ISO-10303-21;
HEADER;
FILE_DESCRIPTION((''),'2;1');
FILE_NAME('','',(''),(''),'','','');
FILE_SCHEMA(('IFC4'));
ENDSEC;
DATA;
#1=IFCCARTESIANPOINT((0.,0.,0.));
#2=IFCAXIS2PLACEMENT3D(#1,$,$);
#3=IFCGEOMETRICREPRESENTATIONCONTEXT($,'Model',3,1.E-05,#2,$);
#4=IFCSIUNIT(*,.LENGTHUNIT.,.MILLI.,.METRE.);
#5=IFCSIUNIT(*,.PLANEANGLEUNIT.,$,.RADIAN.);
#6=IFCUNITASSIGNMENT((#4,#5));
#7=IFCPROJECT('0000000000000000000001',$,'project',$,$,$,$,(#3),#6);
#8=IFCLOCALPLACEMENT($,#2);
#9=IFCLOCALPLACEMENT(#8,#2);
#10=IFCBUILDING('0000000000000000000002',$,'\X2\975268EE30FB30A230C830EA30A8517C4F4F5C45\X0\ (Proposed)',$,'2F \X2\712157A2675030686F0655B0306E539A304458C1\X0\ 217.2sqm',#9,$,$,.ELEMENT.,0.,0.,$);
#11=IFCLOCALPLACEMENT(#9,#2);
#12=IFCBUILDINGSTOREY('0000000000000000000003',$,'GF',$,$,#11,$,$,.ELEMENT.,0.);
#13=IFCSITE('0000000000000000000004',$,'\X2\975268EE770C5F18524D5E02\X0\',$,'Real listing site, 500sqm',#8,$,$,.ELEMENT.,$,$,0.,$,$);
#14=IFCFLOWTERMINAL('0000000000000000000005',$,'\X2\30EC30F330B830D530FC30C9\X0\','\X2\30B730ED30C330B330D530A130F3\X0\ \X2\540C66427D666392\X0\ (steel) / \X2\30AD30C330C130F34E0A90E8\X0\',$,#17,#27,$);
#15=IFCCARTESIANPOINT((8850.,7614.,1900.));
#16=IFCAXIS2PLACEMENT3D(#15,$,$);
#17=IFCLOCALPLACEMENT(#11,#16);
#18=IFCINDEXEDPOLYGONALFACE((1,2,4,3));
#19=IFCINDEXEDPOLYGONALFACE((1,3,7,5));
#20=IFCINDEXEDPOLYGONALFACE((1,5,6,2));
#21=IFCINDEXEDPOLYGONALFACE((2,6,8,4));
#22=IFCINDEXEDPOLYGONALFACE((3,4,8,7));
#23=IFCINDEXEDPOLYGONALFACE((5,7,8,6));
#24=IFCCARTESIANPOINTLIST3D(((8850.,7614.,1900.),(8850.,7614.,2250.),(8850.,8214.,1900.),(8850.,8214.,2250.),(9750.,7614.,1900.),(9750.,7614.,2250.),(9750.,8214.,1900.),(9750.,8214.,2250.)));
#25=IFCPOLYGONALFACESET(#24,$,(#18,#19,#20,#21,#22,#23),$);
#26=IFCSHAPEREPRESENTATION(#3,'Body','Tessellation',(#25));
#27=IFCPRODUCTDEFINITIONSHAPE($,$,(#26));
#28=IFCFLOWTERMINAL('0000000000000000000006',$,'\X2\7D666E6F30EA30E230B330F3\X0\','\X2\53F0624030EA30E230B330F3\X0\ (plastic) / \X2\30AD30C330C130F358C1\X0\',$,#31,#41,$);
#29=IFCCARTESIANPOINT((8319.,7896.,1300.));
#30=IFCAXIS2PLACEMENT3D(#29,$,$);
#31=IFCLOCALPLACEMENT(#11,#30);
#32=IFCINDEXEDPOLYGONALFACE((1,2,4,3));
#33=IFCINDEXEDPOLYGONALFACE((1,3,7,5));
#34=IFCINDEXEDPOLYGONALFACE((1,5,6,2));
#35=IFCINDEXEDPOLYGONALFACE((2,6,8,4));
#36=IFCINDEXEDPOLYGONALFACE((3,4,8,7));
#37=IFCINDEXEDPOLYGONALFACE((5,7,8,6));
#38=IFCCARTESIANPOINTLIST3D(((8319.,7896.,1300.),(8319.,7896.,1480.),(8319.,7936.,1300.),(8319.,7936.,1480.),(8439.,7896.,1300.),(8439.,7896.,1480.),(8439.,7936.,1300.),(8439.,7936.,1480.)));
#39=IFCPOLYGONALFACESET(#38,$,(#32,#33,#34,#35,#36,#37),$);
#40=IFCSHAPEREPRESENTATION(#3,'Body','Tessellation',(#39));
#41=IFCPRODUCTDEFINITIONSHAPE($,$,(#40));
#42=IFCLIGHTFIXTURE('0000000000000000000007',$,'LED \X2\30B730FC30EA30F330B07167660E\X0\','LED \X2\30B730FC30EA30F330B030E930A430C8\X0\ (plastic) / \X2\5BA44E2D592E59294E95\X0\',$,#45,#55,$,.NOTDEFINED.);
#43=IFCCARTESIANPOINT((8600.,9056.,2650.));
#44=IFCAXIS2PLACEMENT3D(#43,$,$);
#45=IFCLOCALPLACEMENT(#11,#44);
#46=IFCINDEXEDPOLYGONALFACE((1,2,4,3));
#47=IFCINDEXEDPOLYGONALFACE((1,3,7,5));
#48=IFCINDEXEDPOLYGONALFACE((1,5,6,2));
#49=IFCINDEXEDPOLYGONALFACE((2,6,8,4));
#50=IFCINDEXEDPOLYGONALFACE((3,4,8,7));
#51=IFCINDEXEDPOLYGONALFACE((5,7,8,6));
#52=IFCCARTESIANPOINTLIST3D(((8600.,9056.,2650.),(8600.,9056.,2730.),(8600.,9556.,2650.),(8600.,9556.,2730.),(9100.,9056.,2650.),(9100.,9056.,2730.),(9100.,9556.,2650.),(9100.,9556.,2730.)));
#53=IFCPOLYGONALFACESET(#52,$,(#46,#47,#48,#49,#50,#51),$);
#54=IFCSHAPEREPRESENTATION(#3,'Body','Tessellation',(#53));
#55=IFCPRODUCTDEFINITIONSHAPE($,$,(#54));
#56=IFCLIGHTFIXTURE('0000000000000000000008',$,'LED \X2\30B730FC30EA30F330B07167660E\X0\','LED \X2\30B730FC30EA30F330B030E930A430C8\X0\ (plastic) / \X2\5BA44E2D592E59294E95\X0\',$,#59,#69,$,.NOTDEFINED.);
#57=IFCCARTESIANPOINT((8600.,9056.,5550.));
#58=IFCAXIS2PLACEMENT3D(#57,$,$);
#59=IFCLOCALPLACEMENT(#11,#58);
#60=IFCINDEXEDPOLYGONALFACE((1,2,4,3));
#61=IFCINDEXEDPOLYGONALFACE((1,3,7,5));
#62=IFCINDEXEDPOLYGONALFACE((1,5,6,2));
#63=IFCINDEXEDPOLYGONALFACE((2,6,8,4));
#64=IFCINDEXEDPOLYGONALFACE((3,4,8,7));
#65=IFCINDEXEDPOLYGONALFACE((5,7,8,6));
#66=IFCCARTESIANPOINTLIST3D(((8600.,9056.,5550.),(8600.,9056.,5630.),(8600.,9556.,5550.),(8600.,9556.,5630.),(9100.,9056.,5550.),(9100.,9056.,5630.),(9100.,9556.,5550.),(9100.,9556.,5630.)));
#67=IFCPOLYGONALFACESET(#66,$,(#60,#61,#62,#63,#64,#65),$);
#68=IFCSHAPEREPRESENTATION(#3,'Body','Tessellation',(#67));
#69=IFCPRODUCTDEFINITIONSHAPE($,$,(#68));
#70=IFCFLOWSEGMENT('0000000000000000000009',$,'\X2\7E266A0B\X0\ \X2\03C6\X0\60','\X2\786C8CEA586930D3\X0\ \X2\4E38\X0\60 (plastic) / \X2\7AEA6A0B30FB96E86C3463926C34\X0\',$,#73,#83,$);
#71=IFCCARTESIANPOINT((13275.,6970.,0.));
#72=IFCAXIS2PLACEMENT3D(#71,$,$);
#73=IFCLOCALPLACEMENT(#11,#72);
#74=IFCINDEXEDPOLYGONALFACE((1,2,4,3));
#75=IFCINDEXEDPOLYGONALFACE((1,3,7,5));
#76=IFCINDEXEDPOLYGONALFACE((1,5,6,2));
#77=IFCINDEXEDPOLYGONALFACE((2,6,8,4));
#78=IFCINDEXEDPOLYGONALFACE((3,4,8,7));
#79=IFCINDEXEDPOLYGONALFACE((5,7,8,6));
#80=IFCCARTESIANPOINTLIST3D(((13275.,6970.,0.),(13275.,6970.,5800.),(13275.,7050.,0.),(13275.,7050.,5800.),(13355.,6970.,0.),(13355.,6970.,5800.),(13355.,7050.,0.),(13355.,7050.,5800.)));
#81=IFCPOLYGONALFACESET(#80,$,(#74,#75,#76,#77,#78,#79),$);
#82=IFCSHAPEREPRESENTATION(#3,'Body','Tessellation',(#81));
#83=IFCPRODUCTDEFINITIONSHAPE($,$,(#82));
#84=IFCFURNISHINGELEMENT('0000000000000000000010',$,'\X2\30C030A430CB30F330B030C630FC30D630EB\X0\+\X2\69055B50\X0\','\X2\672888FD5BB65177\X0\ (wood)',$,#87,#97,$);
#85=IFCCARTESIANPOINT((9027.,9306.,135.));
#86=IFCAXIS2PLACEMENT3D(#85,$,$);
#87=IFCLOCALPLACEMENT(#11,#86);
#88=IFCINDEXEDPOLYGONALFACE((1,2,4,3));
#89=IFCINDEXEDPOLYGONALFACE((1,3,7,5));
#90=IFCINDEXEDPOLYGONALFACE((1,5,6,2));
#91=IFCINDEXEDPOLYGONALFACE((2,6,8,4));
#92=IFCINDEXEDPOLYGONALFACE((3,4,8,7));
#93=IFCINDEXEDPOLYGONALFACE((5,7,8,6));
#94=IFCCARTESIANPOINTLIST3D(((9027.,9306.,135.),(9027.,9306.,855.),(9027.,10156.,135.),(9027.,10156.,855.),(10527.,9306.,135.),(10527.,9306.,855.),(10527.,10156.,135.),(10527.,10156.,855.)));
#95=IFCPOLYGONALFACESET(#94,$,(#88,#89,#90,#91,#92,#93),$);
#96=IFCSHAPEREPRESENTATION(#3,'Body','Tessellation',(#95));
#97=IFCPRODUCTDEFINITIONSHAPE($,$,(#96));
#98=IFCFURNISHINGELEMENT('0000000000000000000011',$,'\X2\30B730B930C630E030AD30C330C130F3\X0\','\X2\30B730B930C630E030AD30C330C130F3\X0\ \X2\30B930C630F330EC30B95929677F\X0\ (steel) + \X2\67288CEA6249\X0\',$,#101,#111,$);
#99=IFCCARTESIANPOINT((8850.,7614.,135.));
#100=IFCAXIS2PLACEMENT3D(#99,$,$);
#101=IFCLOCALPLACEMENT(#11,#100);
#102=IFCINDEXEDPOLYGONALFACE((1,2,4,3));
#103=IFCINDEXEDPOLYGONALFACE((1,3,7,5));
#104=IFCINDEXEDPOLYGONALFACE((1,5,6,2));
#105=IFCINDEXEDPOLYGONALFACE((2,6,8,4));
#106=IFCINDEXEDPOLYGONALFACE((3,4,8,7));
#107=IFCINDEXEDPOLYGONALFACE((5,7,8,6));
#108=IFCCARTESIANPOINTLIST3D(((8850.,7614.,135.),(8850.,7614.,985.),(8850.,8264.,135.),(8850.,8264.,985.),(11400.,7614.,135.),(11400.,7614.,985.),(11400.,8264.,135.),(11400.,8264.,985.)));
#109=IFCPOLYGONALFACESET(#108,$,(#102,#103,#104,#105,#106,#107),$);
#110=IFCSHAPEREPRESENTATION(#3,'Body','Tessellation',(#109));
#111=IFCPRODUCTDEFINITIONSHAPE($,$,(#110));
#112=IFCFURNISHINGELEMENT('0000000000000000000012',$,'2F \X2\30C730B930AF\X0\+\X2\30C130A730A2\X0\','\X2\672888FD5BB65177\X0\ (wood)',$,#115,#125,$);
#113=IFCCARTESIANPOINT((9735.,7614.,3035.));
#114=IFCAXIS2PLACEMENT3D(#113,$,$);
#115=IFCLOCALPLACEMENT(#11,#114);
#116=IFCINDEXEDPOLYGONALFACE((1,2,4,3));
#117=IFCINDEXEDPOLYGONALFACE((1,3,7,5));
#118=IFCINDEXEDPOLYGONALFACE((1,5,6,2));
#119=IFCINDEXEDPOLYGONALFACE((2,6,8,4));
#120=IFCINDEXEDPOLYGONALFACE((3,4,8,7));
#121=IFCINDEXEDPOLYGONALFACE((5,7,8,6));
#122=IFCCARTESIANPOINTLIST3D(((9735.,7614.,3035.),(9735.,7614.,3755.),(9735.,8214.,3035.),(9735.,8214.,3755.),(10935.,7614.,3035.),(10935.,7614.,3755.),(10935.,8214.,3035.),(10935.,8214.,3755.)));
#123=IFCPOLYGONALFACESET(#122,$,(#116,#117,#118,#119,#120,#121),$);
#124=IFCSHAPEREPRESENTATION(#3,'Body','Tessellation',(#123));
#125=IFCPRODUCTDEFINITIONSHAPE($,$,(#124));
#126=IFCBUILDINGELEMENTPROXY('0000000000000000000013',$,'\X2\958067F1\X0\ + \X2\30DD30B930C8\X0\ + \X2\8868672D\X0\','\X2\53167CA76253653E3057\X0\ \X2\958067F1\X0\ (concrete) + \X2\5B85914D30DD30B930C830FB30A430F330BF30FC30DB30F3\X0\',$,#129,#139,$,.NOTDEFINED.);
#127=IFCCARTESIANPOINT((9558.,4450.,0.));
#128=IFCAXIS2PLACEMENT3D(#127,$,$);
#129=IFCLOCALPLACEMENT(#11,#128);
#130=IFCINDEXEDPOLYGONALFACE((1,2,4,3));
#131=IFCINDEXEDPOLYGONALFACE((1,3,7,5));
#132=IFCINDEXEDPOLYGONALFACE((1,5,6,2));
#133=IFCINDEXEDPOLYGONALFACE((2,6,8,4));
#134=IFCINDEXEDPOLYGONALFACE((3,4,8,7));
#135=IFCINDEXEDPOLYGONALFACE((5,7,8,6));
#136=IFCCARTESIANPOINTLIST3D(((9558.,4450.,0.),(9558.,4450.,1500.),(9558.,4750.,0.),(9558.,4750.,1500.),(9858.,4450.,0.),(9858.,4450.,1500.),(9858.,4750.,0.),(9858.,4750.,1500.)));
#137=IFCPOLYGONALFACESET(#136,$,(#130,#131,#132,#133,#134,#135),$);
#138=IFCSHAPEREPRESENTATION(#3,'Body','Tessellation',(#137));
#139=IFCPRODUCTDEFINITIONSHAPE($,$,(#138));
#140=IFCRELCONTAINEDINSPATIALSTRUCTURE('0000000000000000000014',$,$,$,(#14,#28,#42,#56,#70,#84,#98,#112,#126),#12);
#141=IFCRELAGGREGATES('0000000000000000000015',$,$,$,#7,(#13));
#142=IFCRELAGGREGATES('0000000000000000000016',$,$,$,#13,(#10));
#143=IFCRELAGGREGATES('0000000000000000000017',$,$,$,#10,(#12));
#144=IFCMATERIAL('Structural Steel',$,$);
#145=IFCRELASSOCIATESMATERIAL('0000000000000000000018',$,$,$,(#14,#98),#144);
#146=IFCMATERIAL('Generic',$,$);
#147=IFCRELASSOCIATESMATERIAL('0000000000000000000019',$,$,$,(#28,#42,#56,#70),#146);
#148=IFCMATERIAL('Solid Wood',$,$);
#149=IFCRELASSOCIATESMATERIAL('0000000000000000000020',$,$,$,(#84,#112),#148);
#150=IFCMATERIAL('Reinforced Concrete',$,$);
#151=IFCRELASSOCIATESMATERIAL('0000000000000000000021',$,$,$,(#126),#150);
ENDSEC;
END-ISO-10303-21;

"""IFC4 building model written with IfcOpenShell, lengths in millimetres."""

from ifc_helpers import new_model, si_unit, frame, frame_2d, origin, place, context, project, spatial, rectangle, extrude, material, element, save


model = new_model("IFC4")

# Units and contexts
model_context = context("Model", 3, precision=1e-05, world=origin())
ifc_project = project(units=[si_unit("LENGTHUNIT", "METRE", prefix="MILLI"), si_unit("PLANEANGLEUNIT", "RADIAN")], contexts=[model_context])

# Site, building, storey
site_placement = place(None, origin())
site = spatial("IfcSite", under=ifc_project, at=site_placement, Name="青森県弘前市", ObjectType="Real listing site, 500sqm", CompositionType="ELEMENT", RefElevation=0.0)
building_placement = place(site_placement, origin())
building = spatial("IfcBuilding", under=site, at=building_placement, Name="青森・アトリエ兼住居 (Proposed)", ObjectType="2F 無垢材と漆喰の厚い壁 217.2sqm", CompositionType="ELEMENT", ElevationOfRefHeight=0.0, ElevationOfTerrain=0.0)
storey_placement = place(building_placement, origin())
storey = spatial("IfcBuildingStorey", under=building, at=storey_placement, Name="GF", CompositionType="ELEMENT", Elevation=0.0)

# Shared definitions
ifc_material_1 = material(Name="Solid Wood")

# Shared definitions
ifc_material_2 = material(Name="Reinforced Concrete")

# Shared definitions
ifc_material_3 = material(Name="Structural Steel")

# Flow terminals
flow_terminal_1_placement = place(storey_placement, frame((8850.0, 7614.0, 1900.0)))
element("IfcFlowTerminal", 1, at=flow_terminal_1_placement, inside=storey, material=ifc_material_3, Name="レンジフード", Description="シロッコファン 同時給排 (steel) / キッチン上部", context=model_context, shape_type="SweptSolid", body=[
    extrude(rectangle(XDim=900.0, YDim=600.0, at=frame_2d((450.0, 300.0))), frame((8850.0, 7614.0, 1900.0)), (0.0, 0.0, 1.0), 350.0),
])
ifc_material_4 = material(Name="Generic")
flow_terminal_2_placement = place(storey_placement, frame((8319.0, 7896.0, 1300.0)))
element("IfcFlowTerminal", 2, at=flow_terminal_2_placement, inside=storey, material=ifc_material_4, Name="給湯リモコン", Description="台所リモコン (plastic) / キッチン壁", context=model_context, shape_type="SweptSolid", body=[
    extrude(rectangle(XDim=120.0, YDim=40.0, at=frame_2d((60.0, 20.0))), frame((8319.0, 7896.0, 1300.0)), (0.0, 0.0, 1.0), 180.0),
])

# Light fixtures
light_fixture_1_placement = place(storey_placement, frame((8600.0, 9056.0, 2650.0)))
element("IfcLightFixture", 3, at=light_fixture_1_placement, inside=storey, material=ifc_material_4, Name="LED シーリング照明", Description="LED シーリングライト (plastic) / 室中央天井", PredefinedType="NOTDEFINED", context=model_context, shape_type="SweptSolid", body=[
    extrude(rectangle(XDim=500.0, YDim=500.0, at=frame_2d((250.0, 250.0))), frame((8600.0, 9056.0, 2650.0)), (0.0, 0.0, 1.0), 80.0),
])
light_fixture_2_placement = place(storey_placement, frame((8600.0, 9056.0, 5550.0)))
element("IfcLightFixture", 4, at=light_fixture_2_placement, inside=storey, material=ifc_material_4, Name="LED シーリング照明", Description="LED シーリングライト (plastic) / 室中央天井", PredefinedType="NOTDEFINED", context=model_context, shape_type="SweptSolid", body=[
    extrude(rectangle(XDim=500.0, YDim=500.0, at=frame_2d((250.0, 250.0))), frame((8600.0, 9056.0, 5550.0)), (0.0, 0.0, 1.0), 80.0),
])

# Flow segment
flow_segment_placement = place(storey_placement, frame((13275.0, 6970.0, 0.0)))
element("IfcFlowSegment", 5, at=flow_segment_placement, inside=storey, material=ifc_material_4, Name="縦樋 φ60", Description="硬質塩ビ 丸60 (plastic) / 竪樋・雨水排水", context=model_context, shape_type="SweptSolid", body=[
    extrude(rectangle(XDim=80.0, YDim=80.0, at=frame_2d((40.0, 40.0))), frame((13275.0, 6970.0, 0.0)), (0.0, 0.0, 1.0), 5800.0),
])

# Furnishing elements
furnishing_1_placement = place(storey_placement, frame((9027.0, 9306.0, 135.0)))
element("IfcFurnishingElement", 6, at=furnishing_1_placement, inside=storey, material=ifc_material_1, Name="ダイニングテーブル+椅子", Description="木製家具 (wood)", context=model_context, shape_type="SweptSolid", body=[
    extrude(rectangle(XDim=1500.0, YDim=850.0, at=frame_2d((750.0, 425.0))), frame((9027.0, 9306.0, 135.0)), (0.0, 0.0, 1.0), 720.0),
])
furnishing_2_placement = place(storey_placement, frame((8850.0, 7614.0, 135.0)))
element("IfcFurnishingElement", 7, at=furnishing_2_placement, inside=storey, material=ifc_material_3, Name="システムキッチン", Description="システムキッチン ステンレス天板 (steel) + 木質扉", context=model_context, shape_type="SweptSolid", body=[
    extrude(rectangle(XDim=2550.0, YDim=650.0, at=frame_2d((1275.0, 325.0))), frame((8850.0, 7614.0, 135.0)), (0.0, 0.0, 1.0), 850.0),
])
furnishing_3_placement = place(storey_placement, frame((9735.0, 7614.0, 3035.0)))
element("IfcFurnishingElement", 8, at=furnishing_3_placement, inside=storey, material=ifc_material_1, Name="2F デスク+チェア", Description="木製家具 (wood)", context=model_context, shape_type="SweptSolid", body=[
    extrude(rectangle(XDim=1200.0, YDim=600.0, at=frame_2d((600.0, 300.0))), frame((9735.0, 7614.0, 3035.0)), (0.0, 0.0, 1.0), 720.0),
])

# Building element proxy
proxy_placement = place(storey_placement, frame((9558.0, 4450.0, 0.0)))
element("IfcBuildingElementProxy", 9, at=proxy_placement, inside=storey, material=ifc_material_2, Name="門柱 + ポスト + 表札", Description="化粧打放し 門柱 (concrete) + 宅配ポスト・インターホン", PredefinedType="NOTDEFINED", context=model_context, shape_type="SweptSolid", body=[
    extrude(rectangle(XDim=300.0, YDim=300.0, at=frame_2d((150.0, 150.0))), frame((9558.0, 4450.0, 0.0)), (0.0, 0.0, 1.0), 1500.0),
])

save(model, "model.ifc")
